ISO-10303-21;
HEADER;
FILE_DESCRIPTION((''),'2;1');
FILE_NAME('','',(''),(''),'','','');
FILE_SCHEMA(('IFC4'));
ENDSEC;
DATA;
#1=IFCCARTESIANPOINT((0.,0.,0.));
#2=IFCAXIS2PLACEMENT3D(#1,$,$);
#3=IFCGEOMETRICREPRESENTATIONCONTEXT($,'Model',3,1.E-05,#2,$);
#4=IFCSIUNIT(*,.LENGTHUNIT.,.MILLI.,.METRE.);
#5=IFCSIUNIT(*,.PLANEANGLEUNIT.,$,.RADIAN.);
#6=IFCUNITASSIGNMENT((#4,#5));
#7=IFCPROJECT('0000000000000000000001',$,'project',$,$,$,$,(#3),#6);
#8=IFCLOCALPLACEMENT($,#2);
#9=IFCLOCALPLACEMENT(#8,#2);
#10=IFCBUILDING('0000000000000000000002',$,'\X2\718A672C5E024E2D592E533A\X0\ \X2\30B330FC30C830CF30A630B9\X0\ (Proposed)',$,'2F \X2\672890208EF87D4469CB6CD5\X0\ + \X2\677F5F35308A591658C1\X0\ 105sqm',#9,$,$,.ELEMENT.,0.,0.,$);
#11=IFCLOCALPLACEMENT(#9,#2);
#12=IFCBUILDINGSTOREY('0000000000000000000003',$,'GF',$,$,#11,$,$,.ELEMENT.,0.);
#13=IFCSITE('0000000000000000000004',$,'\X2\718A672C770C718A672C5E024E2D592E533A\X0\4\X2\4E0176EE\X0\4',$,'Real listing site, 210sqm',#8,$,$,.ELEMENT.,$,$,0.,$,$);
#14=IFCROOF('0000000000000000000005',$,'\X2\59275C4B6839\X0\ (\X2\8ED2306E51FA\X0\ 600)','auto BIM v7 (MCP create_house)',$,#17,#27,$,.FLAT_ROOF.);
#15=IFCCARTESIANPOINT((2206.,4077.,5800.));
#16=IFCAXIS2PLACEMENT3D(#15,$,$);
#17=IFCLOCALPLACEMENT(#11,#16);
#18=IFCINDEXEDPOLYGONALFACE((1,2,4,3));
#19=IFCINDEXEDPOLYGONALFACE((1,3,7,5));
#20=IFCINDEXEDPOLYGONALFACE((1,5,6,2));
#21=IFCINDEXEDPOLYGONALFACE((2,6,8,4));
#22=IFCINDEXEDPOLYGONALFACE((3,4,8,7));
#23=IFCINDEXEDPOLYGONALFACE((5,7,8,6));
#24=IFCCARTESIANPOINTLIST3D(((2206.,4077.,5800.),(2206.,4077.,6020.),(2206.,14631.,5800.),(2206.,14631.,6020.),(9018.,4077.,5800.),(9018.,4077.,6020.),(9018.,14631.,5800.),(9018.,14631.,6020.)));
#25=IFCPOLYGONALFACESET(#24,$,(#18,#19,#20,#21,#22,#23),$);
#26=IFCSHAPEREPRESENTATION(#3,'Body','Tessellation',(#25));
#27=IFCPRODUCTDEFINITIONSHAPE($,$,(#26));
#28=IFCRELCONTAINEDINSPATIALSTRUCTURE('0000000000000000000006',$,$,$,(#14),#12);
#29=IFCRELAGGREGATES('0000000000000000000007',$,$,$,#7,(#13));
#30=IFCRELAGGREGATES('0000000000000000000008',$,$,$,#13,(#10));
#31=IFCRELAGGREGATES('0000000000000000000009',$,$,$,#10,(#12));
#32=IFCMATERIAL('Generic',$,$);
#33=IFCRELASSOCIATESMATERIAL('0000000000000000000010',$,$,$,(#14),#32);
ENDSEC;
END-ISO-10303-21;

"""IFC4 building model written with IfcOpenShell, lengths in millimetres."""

from ifc_helpers import new_model, si_unit, frame, frame_2d, origin, place, context, project, spatial, rectangle, extrude, material, element, save


model = new_model("IFC4")

# Units and contexts
model_context = context("Model", 3, precision=1e-05, world=origin())
ifc_project = project(units=[si_unit("LENGTHUNIT", "METRE", prefix="MILLI"), si_unit("PLANEANGLEUNIT", "RADIAN")], contexts=[model_context])

# Site, building, storey
site_placement = place(None, origin())
site = spatial("IfcSite", under=ifc_project, at=site_placement, Name="熊本県熊本市中央区4丁目4", ObjectType="Real listing site, 210sqm", CompositionType="ELEMENT", RefElevation=0.0)
building_placement = place(site_placement, origin())
building = spatial("IfcBuilding", under=site, at=building_placement, Name="熊本市中央区 コートハウス (Proposed)", ObjectType="2F 木造軸組構法 + 板張り外壁 105sqm", CompositionType="ELEMENT", ElevationOfRefHeight=0.0, ElevationOfTerrain=0.0)
storey_placement = place(building_placement, origin())
storey = spatial("IfcBuildingStorey", under=building, at=storey_placement, Name="GF", CompositionType="ELEMENT", Elevation=0.0)

# Shared definitions
ifc_material = material(Name="Generic")

# Roof
roof_placement = place(storey_placement, frame((2206.0, 4077.0, 5800.0)))
element("IfcRoof", 1, at=roof_placement, inside=storey, material=ifc_material, Name="大屋根 (軒の出 600)", Description="auto BIM v7 (MCP create_house)", PredefinedType="FLAT_ROOF", context=model_context, shape_type="SweptSolid", body=[
    extrude(rectangle(XDim=6812.0, YDim=10554.0, at=frame_2d((3406.0, 5277.0))), frame((2206.0, 4077.0, 5800.0)), (0.0, 0.0, 1.0), 220.0),
])

save(model, "model.ifc")
